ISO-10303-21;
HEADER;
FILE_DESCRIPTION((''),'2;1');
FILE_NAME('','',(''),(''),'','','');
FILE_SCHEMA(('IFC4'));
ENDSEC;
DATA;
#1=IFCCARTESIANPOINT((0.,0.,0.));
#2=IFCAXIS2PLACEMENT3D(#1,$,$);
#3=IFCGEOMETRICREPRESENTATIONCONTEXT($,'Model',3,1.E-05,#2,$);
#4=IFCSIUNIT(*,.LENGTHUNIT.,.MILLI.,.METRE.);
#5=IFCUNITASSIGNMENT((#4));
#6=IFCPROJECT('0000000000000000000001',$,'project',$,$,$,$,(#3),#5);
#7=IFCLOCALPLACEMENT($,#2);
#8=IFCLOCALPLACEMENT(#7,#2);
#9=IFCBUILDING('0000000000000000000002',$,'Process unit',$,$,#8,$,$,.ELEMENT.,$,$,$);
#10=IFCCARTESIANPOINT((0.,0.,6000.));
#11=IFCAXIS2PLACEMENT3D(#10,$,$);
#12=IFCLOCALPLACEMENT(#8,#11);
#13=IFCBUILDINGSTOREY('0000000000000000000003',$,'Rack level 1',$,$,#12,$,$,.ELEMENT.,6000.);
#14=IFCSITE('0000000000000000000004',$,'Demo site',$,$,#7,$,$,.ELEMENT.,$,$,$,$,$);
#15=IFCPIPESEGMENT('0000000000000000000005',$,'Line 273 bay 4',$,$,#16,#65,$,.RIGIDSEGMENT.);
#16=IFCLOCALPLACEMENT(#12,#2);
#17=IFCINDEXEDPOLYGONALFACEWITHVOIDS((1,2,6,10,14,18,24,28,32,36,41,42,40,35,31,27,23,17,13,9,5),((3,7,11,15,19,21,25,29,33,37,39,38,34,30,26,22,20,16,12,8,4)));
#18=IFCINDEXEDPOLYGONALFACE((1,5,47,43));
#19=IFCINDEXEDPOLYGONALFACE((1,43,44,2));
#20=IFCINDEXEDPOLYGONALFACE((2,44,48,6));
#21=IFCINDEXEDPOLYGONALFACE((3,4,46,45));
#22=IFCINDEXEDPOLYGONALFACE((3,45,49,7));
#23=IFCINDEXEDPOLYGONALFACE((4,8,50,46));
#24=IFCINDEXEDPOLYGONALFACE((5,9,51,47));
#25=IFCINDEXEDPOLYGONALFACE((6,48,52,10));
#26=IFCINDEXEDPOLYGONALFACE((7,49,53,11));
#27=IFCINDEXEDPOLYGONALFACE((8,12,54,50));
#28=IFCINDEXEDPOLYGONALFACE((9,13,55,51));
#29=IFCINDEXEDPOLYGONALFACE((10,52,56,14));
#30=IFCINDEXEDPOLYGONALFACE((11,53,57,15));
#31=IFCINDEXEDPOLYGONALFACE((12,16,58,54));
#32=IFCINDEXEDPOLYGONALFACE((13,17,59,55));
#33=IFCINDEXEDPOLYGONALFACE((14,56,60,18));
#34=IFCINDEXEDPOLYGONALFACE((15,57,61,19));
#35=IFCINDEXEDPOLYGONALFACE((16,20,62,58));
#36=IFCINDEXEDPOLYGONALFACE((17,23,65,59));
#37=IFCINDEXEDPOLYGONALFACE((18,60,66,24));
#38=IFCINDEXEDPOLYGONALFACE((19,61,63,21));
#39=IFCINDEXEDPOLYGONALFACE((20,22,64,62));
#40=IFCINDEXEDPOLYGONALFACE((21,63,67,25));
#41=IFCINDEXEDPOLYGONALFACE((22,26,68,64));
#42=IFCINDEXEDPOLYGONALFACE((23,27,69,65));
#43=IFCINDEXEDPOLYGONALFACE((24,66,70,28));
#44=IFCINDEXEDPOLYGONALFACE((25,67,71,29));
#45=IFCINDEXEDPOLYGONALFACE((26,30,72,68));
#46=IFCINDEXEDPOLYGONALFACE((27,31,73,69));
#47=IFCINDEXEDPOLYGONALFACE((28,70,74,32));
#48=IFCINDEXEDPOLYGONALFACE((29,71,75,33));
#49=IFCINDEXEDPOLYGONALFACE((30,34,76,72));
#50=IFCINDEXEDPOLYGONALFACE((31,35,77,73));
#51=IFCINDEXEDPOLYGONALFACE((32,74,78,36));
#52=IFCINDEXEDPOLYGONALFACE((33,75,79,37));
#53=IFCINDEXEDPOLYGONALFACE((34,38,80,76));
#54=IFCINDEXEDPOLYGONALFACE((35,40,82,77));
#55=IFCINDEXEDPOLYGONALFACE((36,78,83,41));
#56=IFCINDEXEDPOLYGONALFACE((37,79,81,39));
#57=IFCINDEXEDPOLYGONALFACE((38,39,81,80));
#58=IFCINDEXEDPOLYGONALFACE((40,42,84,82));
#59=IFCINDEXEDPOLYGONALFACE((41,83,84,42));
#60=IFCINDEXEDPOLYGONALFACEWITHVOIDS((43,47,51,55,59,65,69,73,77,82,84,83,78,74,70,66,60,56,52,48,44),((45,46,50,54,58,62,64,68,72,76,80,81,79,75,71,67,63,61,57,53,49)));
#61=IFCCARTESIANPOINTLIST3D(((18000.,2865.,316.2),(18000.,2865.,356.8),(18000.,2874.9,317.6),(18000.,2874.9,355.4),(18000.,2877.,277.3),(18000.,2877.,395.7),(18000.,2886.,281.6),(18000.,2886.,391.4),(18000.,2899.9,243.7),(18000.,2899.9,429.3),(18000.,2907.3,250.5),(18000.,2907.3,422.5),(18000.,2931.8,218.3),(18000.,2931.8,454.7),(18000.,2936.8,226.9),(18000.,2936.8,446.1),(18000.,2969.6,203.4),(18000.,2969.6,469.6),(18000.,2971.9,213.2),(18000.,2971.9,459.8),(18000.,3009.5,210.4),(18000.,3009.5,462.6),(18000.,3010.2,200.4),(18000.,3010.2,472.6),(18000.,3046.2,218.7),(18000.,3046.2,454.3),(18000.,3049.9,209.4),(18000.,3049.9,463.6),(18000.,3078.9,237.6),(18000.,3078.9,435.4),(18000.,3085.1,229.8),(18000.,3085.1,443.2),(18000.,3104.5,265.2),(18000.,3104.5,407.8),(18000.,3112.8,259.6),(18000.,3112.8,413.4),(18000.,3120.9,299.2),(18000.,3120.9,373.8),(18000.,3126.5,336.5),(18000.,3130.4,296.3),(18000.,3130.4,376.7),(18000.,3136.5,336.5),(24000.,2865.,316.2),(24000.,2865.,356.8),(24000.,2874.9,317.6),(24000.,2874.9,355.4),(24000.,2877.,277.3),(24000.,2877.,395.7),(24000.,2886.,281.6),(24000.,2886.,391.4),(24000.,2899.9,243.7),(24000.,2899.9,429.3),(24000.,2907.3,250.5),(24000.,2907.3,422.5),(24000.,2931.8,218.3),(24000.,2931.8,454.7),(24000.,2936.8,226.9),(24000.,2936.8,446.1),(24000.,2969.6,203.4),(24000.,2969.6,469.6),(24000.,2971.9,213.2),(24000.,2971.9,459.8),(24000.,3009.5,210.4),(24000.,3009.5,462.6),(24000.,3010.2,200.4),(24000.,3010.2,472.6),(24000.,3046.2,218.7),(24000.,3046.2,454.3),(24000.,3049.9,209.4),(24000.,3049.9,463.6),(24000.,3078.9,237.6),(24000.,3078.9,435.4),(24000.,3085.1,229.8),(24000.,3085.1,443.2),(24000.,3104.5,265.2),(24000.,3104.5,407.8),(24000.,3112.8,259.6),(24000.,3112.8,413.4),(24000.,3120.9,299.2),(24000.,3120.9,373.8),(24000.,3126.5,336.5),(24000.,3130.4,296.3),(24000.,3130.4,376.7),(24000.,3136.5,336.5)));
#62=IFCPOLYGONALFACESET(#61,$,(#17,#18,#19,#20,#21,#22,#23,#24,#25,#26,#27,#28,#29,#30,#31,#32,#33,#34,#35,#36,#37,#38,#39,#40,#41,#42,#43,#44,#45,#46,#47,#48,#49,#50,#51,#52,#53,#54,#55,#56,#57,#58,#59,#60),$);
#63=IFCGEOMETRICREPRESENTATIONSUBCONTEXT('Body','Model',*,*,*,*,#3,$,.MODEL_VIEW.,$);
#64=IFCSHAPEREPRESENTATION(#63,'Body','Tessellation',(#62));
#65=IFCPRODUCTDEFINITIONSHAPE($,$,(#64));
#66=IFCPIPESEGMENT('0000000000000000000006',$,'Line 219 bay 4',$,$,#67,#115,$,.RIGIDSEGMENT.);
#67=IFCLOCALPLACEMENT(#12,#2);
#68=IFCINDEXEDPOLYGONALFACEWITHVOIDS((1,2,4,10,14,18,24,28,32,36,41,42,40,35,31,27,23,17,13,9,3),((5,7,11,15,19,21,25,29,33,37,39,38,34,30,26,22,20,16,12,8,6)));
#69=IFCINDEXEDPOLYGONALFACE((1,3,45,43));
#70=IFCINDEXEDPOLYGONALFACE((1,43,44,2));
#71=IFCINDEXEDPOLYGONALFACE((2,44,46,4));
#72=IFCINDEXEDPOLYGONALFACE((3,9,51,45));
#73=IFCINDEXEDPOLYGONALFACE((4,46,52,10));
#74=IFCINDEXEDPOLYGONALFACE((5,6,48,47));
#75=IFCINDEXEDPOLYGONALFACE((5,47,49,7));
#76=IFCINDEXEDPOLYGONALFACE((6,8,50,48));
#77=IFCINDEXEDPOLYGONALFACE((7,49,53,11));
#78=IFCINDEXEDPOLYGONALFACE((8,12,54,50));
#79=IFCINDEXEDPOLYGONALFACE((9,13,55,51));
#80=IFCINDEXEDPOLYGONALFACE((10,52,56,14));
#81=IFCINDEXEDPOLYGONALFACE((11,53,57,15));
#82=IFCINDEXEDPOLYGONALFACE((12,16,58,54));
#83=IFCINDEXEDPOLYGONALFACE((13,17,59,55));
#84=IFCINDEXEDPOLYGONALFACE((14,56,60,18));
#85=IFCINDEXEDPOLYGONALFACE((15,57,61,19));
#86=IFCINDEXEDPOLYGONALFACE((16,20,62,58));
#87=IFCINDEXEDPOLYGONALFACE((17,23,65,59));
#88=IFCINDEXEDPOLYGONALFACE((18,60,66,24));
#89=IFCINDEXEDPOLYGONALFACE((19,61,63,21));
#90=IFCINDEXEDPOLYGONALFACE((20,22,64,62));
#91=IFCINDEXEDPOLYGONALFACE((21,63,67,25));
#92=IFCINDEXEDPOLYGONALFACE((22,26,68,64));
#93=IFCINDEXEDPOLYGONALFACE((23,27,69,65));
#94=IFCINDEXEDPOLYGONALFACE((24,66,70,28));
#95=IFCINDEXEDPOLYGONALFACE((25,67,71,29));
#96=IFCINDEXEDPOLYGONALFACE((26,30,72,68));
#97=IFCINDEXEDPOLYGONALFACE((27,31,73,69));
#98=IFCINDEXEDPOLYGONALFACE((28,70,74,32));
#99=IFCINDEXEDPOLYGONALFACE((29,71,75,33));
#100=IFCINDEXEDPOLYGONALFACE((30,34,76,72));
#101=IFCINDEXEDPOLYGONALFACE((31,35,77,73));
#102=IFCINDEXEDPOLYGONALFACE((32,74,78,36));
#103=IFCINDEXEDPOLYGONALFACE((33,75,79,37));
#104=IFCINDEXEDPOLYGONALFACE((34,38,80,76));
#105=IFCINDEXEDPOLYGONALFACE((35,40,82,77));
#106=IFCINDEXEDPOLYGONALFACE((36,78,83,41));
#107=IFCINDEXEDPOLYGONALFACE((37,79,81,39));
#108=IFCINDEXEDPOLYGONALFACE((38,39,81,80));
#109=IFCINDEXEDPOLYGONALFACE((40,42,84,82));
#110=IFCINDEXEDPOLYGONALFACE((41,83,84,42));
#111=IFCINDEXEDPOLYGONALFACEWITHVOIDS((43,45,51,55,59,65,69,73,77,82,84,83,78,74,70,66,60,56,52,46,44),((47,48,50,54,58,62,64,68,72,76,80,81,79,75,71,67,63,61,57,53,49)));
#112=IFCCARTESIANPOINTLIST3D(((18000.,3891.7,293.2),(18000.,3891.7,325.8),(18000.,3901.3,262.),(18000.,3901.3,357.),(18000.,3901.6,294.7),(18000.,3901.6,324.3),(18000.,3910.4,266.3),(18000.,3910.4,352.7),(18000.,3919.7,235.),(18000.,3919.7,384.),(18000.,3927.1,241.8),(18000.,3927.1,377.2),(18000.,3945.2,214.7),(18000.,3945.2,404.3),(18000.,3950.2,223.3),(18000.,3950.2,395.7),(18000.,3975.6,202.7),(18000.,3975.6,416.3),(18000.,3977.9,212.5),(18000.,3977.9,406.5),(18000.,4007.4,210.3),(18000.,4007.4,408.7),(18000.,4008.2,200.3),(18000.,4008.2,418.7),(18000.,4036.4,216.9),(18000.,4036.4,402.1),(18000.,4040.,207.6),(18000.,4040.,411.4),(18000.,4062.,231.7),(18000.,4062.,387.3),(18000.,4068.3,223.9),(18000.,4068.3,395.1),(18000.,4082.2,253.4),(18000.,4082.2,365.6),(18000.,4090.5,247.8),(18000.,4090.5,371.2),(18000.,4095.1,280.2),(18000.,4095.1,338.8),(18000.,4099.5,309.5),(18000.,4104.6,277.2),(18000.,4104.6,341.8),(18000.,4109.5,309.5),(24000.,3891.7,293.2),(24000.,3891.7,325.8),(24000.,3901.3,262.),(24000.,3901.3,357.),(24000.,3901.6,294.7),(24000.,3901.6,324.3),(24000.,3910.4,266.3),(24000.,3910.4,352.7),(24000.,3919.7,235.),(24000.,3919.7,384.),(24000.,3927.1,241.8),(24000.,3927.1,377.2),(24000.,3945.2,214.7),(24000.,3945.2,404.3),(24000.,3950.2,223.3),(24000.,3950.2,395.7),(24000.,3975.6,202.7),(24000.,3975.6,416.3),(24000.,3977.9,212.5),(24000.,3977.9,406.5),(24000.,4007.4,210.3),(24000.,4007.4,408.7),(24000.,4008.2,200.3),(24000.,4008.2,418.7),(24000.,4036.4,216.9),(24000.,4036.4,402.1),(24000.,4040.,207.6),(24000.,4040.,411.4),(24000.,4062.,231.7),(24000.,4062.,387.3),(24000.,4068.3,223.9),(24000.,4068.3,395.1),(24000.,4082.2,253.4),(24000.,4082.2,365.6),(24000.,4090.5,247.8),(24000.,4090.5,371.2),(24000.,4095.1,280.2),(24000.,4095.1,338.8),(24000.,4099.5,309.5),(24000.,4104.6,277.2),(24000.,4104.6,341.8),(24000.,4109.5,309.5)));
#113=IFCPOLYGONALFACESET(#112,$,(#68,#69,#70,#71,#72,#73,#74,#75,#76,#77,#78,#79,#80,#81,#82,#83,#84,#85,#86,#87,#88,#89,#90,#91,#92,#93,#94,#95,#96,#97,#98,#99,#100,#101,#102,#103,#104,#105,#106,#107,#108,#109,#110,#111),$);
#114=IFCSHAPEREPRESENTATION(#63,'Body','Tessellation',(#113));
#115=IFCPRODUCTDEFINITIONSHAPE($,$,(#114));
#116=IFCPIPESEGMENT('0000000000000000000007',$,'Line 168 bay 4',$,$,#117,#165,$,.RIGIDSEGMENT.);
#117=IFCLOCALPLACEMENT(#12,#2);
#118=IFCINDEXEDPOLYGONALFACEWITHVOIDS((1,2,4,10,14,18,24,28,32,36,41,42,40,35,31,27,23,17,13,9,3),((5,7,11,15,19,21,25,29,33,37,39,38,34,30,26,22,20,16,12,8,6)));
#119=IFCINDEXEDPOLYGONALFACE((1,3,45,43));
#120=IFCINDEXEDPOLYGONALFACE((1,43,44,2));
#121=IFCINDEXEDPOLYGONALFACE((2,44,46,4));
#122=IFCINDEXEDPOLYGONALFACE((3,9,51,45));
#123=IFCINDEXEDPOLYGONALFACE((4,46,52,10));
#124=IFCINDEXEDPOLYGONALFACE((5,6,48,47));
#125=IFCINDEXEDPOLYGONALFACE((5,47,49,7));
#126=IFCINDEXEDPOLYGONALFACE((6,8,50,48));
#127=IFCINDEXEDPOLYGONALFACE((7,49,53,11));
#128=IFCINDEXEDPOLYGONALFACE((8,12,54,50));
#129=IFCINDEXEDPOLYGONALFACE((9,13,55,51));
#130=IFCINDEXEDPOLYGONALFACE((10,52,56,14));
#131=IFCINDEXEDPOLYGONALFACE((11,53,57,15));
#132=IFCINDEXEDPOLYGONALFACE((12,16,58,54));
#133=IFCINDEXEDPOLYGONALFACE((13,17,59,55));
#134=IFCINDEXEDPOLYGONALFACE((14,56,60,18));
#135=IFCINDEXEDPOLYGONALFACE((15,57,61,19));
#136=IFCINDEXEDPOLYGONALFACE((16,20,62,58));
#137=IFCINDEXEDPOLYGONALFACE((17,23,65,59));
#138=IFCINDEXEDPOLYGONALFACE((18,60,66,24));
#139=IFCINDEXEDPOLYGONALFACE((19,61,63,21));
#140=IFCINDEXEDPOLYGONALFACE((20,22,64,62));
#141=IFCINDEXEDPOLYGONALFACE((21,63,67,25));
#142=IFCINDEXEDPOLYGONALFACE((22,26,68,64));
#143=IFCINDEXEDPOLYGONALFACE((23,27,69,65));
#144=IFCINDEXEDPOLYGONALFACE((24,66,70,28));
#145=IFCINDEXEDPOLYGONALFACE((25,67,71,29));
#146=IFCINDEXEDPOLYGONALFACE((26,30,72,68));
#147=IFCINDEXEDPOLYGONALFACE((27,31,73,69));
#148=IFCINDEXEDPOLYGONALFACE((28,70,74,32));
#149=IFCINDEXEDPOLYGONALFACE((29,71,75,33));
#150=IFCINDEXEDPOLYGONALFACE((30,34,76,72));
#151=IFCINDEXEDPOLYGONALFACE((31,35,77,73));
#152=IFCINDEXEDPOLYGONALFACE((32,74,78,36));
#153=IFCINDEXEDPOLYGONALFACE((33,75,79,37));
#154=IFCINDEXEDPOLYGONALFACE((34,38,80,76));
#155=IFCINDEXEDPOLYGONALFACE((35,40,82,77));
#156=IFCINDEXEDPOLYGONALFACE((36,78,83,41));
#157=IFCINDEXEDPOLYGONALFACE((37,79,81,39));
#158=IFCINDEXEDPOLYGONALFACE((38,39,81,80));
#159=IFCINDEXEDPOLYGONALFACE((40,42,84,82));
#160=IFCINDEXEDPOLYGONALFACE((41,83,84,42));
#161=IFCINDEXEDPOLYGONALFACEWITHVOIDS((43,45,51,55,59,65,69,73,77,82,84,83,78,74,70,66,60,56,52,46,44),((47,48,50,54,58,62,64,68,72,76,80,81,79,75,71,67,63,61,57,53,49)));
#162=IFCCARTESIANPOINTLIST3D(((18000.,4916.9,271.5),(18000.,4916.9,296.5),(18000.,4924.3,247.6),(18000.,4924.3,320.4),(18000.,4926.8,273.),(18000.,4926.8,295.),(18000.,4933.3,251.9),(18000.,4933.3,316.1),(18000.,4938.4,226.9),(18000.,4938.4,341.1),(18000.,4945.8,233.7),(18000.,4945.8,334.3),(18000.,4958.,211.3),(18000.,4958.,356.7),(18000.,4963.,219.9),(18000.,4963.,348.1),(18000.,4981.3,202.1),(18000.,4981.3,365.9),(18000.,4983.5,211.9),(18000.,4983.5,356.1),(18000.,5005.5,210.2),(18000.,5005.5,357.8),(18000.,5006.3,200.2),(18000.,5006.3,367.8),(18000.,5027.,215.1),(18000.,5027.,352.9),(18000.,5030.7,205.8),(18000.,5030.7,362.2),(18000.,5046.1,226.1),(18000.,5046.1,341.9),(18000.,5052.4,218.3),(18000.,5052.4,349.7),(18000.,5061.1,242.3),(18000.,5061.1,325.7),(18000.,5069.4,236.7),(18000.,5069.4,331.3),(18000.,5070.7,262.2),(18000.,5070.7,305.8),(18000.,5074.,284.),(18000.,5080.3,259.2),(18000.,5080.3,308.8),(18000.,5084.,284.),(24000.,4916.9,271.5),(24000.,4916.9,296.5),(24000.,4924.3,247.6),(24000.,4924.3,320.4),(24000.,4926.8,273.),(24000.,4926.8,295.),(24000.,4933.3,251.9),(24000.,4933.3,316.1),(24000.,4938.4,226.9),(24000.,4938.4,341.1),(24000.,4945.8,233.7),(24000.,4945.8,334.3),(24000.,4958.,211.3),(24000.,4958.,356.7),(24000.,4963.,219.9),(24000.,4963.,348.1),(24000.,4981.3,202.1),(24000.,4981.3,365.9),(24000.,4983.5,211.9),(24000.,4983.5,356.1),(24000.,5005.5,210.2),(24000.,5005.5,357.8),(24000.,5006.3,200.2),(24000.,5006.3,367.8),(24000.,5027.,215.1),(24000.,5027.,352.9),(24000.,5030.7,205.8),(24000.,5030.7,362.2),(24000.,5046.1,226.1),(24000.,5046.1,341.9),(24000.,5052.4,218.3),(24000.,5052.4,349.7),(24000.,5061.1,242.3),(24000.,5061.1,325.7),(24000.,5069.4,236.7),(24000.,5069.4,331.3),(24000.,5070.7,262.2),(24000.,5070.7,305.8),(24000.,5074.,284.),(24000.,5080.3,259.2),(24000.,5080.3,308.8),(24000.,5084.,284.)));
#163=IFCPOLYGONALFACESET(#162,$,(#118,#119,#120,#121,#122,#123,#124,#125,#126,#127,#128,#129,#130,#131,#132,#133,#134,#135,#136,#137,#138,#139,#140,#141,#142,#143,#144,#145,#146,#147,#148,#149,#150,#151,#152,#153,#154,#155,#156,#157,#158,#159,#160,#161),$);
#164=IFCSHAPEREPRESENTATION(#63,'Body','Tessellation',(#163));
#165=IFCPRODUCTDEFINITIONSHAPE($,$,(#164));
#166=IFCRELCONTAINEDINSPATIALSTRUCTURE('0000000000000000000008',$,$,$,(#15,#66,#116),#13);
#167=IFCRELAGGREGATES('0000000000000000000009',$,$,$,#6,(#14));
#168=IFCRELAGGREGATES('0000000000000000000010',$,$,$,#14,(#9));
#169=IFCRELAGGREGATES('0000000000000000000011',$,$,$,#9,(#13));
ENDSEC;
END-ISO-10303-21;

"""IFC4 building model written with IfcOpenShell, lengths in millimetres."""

from ifc_helpers import new_model, si_unit, frame, origin, place, context, subcontext, project, spatial, hollow_circle, extrude, element, save


model = new_model("IFC4")

# Units and contexts
model_context = context("Model", 3, precision=1e-05, world=origin())
body_context = subcontext(model_context, "Body", "Model", "MODEL_VIEW")
ifc_project = project(units=[si_unit("LENGTHUNIT", "METRE", prefix="MILLI")], contexts=[model_context])

# Site, building, storey
site_placement = place(None, origin())
site = spatial("IfcSite", under=ifc_project, at=site_placement, Name="Demo site", CompositionType="ELEMENT")
building_placement = place(site_placement, origin())
building = spatial("IfcBuilding", under=site, at=building_placement, Name="Process unit", CompositionType="ELEMENT")
storey_placement = place(building_placement, frame((0.0, 0.0, 6000.0)))
storey = spatial("IfcBuildingStorey", under=building, at=storey_placement, Name="Rack level 1", CompositionType="ELEMENT", Elevation=6000.0)

# Pipe segments
pipe_segment_1_placement = place(storey_placement, frame((18000.0, 3000.0, 336.5)))
element("IfcPipeSegment", 1, at=pipe_segment_1_placement, inside=storey, Name="Line 273 bay 4", PredefinedType="RIGIDSEGMENT", context=body_context, shape_type="SweptSolid", body=[
    extrude(hollow_circle(Radius=136.5, WallThickness=10.0), frame((0.0, 0.0, 0.0), z_axis=(1.0, 0.0, 0.0), x_axis=(0.0, 1.0, 0.0)), (0.0, 0.0, 1.0), 6000.0),
])
pipe_segment_2_placement = place(storey_placement, frame((18000.0, 4000.0, 309.5)))
element("IfcPipeSegment", 2, at=pipe_segment_2_placement, inside=storey, Name="Line 219 bay 4", PredefinedType="RIGIDSEGMENT", context=body_context, shape_type="SweptSolid", body=[
    extrude(hollow_circle(Radius=109.5, WallThickness=10.0), frame((0.0, 0.0, 0.0), z_axis=(1.0, 0.0, 0.0), x_axis=(0.0, 1.0, 0.0)), (0.0, 0.0, 1.0), 6000.0),
])
pipe_segment_3_placement = place(storey_placement, frame((18000.0, 5000.0, 284.0)))
element("IfcPipeSegment", 3, at=pipe_segment_3_placement, inside=storey, Name="Line 168 bay 4", PredefinedType="RIGIDSEGMENT", context=body_context, shape_type="SweptSolid", body=[
    extrude(hollow_circle(Radius=84.0, WallThickness=10.0), frame((0.0, 0.0, 0.0), z_axis=(1.0, 0.0, 0.0), x_axis=(0.0, 1.0, 0.0)), (0.0, 0.0, 1.0), 6000.0),
])

save(model, "model.ifc")
